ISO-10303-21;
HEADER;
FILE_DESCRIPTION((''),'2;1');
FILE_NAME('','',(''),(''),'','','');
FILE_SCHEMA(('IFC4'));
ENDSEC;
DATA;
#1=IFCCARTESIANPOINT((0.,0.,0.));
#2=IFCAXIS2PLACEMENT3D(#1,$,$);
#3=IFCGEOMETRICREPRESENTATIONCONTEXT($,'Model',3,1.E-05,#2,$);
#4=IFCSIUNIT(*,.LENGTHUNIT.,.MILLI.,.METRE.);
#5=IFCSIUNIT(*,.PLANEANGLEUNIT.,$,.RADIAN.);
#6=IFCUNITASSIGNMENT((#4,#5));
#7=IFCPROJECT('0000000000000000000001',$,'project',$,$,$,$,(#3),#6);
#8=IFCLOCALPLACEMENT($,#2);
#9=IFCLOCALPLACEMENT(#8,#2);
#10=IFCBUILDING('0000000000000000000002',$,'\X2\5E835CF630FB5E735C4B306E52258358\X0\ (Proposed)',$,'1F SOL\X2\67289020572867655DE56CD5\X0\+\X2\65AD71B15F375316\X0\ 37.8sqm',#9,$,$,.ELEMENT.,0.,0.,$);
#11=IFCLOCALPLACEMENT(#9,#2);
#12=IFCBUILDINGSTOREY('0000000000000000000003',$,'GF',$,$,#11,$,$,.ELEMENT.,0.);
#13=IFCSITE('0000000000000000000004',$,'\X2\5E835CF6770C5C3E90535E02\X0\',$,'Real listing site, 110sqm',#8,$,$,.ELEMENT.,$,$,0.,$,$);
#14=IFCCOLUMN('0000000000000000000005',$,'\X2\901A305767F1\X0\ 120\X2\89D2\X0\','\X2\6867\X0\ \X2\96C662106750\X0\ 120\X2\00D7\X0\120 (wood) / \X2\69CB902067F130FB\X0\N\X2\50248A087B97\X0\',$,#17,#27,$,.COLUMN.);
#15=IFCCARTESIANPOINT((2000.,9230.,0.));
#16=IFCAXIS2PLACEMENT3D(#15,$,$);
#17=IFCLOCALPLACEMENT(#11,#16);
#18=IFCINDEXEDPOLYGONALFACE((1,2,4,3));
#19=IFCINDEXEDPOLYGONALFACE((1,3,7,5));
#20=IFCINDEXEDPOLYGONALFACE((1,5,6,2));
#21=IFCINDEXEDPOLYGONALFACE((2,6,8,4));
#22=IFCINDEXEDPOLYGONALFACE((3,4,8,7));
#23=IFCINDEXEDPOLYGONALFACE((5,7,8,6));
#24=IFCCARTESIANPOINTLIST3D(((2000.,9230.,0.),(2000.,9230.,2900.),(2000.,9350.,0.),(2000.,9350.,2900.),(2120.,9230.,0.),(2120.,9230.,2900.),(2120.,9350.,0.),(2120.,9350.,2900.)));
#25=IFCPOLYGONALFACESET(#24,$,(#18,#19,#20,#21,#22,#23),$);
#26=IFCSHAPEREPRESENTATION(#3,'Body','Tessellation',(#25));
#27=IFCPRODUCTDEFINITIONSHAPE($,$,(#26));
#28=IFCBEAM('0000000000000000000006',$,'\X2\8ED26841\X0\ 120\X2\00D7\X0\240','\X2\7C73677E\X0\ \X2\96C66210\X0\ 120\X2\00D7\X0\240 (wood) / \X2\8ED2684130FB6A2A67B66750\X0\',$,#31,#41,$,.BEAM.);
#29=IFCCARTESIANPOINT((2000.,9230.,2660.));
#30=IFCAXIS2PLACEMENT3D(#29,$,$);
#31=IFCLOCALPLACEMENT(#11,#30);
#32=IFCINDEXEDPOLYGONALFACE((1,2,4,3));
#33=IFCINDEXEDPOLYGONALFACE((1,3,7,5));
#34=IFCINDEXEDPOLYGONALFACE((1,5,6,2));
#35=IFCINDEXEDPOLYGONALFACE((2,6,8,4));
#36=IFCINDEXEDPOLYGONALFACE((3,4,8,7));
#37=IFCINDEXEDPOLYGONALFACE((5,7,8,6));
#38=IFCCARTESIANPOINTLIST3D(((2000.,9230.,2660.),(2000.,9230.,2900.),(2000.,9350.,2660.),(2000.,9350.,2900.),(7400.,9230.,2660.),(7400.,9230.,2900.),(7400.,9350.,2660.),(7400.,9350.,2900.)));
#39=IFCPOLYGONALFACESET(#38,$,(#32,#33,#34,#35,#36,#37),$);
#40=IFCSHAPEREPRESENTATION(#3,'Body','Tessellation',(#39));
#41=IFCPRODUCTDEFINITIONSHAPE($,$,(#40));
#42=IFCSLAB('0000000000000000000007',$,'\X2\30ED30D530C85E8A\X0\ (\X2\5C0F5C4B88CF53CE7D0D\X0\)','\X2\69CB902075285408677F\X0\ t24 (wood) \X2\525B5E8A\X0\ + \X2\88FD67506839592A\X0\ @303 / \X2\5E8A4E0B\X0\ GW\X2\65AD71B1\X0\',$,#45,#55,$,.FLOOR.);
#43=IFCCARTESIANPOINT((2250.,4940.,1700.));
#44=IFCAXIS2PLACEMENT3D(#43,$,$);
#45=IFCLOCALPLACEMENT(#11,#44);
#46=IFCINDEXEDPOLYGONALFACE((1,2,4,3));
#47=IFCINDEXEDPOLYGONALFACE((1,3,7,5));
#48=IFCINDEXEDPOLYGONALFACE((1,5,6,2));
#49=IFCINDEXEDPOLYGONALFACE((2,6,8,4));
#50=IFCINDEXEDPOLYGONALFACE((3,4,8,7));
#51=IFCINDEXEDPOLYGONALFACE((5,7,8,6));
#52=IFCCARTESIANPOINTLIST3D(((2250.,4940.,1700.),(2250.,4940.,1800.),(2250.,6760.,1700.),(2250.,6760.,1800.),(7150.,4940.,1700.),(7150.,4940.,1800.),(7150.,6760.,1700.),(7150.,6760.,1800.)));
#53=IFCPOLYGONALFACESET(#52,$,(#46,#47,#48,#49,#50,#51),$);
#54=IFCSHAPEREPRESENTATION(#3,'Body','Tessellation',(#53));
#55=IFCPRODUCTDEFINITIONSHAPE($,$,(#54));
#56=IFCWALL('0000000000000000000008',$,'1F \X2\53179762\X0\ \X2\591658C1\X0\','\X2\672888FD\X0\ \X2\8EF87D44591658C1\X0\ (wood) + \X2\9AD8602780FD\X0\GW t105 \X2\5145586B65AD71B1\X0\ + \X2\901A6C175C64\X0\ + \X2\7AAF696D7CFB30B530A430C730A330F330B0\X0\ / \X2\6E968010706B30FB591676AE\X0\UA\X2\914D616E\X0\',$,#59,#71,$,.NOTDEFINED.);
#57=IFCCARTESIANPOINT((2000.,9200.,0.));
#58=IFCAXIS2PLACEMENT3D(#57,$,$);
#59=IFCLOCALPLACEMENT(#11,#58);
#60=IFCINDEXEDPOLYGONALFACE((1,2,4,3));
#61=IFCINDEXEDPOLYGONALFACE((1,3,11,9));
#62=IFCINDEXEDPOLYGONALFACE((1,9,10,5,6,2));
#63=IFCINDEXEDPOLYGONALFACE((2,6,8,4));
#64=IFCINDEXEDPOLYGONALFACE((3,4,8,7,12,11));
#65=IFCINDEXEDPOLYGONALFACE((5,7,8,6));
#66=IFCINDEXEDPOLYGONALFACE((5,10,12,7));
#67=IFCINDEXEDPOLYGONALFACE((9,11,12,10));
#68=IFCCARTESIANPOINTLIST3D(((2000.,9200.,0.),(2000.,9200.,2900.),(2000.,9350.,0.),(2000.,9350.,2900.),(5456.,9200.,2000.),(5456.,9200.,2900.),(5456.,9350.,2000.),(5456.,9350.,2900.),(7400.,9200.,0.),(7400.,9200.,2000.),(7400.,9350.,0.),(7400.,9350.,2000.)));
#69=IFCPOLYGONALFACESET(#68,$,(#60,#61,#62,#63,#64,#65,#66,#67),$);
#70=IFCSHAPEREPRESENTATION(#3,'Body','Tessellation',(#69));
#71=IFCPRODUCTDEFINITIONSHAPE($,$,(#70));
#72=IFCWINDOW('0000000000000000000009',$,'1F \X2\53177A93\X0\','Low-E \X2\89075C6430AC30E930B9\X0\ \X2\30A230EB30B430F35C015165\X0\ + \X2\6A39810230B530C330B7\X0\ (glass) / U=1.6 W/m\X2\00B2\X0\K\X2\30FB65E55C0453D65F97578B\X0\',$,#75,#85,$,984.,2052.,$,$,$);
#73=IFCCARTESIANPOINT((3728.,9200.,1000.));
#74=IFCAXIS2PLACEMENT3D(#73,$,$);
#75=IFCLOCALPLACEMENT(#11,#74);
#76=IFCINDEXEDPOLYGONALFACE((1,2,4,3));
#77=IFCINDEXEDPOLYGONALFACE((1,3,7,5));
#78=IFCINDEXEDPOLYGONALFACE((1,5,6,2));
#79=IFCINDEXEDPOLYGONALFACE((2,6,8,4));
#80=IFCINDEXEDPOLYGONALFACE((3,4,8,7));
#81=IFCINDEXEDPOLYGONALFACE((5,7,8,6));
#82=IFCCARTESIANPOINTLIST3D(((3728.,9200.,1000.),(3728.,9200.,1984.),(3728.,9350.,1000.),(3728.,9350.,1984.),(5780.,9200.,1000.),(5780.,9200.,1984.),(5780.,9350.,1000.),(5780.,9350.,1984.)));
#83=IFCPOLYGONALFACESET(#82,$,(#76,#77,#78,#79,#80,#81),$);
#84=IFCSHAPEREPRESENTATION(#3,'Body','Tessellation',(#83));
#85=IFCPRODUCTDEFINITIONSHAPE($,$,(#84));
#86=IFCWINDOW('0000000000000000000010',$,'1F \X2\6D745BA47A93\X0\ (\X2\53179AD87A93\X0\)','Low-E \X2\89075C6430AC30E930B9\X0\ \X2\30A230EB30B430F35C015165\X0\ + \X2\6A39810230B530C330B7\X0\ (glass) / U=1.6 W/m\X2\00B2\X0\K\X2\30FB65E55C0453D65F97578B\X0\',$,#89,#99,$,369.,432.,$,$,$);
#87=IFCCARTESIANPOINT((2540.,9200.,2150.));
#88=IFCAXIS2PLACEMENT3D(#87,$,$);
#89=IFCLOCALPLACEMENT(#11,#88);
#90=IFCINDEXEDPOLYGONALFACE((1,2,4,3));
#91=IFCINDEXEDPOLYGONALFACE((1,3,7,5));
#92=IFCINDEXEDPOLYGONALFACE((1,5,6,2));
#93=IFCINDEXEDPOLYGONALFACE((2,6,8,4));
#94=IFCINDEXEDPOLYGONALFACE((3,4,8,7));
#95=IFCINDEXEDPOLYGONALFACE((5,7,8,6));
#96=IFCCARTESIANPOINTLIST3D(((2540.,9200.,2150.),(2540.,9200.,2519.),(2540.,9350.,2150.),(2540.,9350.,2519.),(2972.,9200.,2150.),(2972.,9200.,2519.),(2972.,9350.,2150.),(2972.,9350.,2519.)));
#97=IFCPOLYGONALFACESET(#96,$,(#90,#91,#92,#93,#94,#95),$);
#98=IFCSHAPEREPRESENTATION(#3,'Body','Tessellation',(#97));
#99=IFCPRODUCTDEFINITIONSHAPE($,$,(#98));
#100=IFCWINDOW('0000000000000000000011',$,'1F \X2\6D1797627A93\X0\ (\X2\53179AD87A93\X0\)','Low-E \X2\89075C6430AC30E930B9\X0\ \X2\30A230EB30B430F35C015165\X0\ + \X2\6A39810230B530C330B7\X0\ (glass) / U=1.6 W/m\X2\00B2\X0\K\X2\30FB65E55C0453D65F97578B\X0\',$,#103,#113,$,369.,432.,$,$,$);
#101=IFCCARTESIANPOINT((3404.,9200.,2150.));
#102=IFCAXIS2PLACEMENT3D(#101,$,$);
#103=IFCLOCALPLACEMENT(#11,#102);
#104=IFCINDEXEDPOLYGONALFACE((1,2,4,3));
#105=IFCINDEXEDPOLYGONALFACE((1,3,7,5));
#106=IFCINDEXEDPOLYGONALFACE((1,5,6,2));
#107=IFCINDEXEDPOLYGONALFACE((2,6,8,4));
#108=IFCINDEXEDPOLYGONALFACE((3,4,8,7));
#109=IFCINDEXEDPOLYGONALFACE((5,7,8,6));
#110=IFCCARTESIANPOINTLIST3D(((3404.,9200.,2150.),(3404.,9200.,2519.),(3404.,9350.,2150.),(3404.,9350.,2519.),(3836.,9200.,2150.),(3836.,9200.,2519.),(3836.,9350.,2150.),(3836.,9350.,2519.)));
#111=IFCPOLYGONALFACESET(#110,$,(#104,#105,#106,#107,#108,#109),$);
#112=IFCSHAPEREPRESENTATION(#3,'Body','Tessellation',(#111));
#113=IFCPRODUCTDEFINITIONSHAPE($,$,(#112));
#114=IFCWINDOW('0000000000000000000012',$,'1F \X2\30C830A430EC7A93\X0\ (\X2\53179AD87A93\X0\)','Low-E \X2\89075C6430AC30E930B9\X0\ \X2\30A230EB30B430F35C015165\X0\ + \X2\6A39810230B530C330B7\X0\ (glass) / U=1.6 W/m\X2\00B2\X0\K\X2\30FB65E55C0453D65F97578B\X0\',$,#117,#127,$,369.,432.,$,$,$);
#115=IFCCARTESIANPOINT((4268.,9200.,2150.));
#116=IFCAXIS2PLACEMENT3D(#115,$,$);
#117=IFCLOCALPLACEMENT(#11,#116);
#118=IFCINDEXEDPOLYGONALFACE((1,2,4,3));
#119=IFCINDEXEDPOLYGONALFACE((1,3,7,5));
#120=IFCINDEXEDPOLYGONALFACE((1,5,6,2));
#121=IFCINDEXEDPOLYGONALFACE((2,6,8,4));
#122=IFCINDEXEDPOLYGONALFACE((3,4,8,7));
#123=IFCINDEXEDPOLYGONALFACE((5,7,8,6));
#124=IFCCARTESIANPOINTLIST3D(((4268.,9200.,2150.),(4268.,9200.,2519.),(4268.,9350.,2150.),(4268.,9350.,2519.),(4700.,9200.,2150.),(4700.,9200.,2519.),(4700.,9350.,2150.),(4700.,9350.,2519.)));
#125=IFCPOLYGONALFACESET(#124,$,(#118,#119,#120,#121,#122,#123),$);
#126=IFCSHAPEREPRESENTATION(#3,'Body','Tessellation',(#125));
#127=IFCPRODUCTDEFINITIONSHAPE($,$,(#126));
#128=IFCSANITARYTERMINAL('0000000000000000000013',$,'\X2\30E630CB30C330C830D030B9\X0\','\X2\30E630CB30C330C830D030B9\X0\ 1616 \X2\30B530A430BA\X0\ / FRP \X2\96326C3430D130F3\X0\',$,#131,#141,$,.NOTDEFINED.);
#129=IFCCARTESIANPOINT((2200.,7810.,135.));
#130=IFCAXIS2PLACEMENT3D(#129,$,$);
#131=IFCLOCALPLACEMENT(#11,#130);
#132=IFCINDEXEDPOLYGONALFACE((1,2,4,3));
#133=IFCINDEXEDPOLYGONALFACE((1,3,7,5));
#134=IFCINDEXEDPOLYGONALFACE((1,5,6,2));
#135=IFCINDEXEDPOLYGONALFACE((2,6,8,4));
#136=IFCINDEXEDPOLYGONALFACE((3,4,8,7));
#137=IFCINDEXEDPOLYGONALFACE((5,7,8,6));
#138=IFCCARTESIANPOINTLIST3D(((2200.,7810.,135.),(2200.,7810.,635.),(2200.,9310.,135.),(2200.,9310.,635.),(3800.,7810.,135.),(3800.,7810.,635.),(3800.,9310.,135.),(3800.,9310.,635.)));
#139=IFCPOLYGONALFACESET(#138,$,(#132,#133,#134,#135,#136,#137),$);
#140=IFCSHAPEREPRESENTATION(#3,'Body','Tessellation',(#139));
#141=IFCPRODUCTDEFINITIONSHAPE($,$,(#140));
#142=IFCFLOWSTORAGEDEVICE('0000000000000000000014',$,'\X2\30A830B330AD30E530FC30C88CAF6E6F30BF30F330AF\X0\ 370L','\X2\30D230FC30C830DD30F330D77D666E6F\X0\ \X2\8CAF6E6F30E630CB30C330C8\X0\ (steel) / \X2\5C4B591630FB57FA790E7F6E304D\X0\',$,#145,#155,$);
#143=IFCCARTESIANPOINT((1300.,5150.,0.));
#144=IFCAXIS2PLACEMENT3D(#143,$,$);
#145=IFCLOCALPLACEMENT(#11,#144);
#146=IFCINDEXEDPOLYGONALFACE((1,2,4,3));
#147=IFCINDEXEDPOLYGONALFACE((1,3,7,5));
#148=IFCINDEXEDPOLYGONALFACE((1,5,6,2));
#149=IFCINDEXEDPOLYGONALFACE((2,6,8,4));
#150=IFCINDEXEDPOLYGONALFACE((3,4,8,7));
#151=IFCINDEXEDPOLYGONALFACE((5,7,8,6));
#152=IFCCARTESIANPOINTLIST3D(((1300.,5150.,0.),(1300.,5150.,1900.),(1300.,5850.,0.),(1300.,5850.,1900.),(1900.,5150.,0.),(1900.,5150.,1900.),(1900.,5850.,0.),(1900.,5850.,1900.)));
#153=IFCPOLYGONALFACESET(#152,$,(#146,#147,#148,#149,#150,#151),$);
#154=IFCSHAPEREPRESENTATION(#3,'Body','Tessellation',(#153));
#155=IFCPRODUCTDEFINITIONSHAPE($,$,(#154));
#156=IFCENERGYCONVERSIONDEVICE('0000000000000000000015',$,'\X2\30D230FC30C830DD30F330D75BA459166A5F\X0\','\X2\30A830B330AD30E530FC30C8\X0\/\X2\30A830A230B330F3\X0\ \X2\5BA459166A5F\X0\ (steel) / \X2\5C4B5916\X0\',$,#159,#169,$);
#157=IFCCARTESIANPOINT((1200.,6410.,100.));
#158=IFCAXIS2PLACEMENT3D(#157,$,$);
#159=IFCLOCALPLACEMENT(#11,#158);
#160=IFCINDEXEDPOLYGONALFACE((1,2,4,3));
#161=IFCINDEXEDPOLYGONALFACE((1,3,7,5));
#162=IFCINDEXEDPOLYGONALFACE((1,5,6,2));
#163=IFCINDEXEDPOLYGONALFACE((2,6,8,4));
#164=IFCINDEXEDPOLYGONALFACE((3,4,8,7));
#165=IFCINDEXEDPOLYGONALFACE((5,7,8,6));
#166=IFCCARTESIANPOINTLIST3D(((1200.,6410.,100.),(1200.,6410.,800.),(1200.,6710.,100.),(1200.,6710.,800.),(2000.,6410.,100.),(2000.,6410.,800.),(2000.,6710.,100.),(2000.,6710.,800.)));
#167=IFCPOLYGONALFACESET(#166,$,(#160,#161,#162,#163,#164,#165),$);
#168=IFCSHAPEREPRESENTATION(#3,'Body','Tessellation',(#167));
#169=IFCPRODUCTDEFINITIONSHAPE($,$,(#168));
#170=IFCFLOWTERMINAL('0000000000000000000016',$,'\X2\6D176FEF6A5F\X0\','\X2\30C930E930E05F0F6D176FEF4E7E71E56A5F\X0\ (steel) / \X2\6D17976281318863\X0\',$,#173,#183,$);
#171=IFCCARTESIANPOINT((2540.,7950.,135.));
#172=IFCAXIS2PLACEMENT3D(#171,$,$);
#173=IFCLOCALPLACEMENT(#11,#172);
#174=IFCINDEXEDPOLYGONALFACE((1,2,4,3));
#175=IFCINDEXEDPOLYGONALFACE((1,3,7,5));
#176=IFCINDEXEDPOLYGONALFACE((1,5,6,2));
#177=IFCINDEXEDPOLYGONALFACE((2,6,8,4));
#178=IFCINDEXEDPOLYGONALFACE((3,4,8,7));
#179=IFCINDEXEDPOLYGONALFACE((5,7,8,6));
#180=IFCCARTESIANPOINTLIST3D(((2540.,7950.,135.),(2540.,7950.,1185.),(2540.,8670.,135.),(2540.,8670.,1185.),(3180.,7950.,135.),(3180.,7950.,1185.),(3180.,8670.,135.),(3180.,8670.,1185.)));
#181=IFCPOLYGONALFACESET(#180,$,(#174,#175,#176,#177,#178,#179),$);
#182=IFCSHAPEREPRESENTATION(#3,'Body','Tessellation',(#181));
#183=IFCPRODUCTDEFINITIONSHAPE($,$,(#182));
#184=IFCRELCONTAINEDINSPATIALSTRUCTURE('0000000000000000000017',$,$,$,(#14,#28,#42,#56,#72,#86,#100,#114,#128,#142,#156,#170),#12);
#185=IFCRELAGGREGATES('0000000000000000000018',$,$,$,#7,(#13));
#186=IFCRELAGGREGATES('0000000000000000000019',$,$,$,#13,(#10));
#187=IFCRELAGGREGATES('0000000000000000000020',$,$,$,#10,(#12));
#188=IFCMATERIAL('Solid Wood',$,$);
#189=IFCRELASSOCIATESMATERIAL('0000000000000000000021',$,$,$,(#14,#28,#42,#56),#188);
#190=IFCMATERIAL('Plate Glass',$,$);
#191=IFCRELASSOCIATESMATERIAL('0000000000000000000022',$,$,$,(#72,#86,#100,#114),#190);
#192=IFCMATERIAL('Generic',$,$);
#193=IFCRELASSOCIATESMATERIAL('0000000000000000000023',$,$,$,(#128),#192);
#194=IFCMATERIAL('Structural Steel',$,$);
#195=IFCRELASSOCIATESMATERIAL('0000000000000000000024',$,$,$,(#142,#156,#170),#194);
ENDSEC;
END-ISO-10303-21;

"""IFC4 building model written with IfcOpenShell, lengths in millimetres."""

from ifc_helpers import new_model, si_unit, frame, frame_2d, origin, place, context, project, spatial, rectangle, extrude, material, element, fill, save


model = new_model("IFC4")

# Units and contexts
model_context = context("Model", 3, precision=1e-05, world=origin())
ifc_project = project(units=[si_unit("LENGTHUNIT", "METRE", prefix="MILLI"), si_unit("PLANEANGLEUNIT", "RADIAN")], contexts=[model_context])

# Site, building, storey
site_placement = place(None, origin())
site = spatial("IfcSite", under=ifc_project, at=site_placement, Name="広島県尾道市", ObjectType="Real listing site, 110sqm", CompositionType="ELEMENT", RefElevation=0.0)
building_placement = place(site_placement, origin())
building = spatial("IfcBuilding", under=site, at=building_placement, Name="広島・平屋の別荘 (Proposed)", ObjectType="1F SOL木造在来工法+断熱強化 37.8sqm", CompositionType="ELEMENT", ElevationOfRefHeight=0.0, ElevationOfTerrain=0.0)
storey_placement = place(building_placement, origin())
storey = spatial("IfcBuildingStorey", under=building, at=storey_placement, Name="GF", CompositionType="ELEMENT", Elevation=0.0)

# Column
ifc_material_1 = material(Name="Solid Wood")
column_1_placement = place(storey_placement, frame((2000.0, 9230.0, 0.0)))
element("IfcColumn", 1, at=column_1_placement, inside=storey, material=ifc_material_1, Name="通し柱 120角", Description="桧 集成材 120×120 (wood) / 構造柱・N値計算", PredefinedType="COLUMN", context=model_context, shape_type="SweptSolid", body=[
    extrude(rectangle(XDim=120.0, YDim=120.0, at=frame_2d((60.0, 60.0))), frame((2000.0, 9230.0, 0.0)), (0.0, 0.0, 1.0), 2900.0),
])

# Beam
beam_1_placement = place(storey_placement, frame((2000.0, 9230.0, 2660.0)))
element("IfcBeam", 2, at=beam_1_placement, inside=storey, material=ifc_material_1, Name="軒桁 120×240", Description="米松 集成 120×240 (wood) / 軒桁・横架材", PredefinedType="BEAM", context=model_context, shape_type="SweptSolid", body=[
    extrude(rectangle(XDim=5400.0, YDim=120.0, at=frame_2d((2700.0, 60.0))), frame((2000.0, 9230.0, 2660.0)), (0.0, 0.0, 1.0), 240.0),
])

# Slab
slab_placement = place(storey_placement, frame((2250.0, 4940.0, 1700.0)))
element("IfcSlab", 3, at=slab_placement, inside=storey, material=ifc_material_1, Name="ロフト床 (小屋裏収納)", Description="構造用合板 t24 (wood) 剛床 + 製材根太 @303 / 床下 GW断熱", PredefinedType="FLOOR", context=model_context, shape_type="SweptSolid", body=[
    extrude(rectangle(XDim=4900.0, YDim=1820.0, at=frame_2d((2450.0, 910.0))), frame((2250.0, 4940.0, 1700.0)), (0.0, 0.0, 1.0), 100.0),
])

# Wall, openings, windows
wall_1_placement = place(storey_placement, frame((2000.0, 9200.0, 0.0)))
wall_1 = element("IfcWall", 4, at=wall_1_placement, inside=storey, material=ifc_material_1, Name="1F 北面 外壁", Description="木製 軸組外壁 (wood) + 高性能GW t105 充填断熱 + 通気層 + 窯業系サイディング / 準耐火・外皮UA配慮", PredefinedType="NOTDEFINED", context=model_context, shape_type="SweptSolid", body=[
    extrude(rectangle(XDim=5400.0, YDim=150.0, at=frame_2d((2700.0, 75.0))), frame((2000.0, 9200.0, 0.0)), (0.0, 0.0, 1.0), 2900.0),
])
opening_1_placement = place(storey_placement, frame((3728.0, 9200.0, 1000.0)))
opening_1 = element("IfcOpeningElement", 5, at=opening_1_placement, cuts=wall_1, PredefinedType="NOTDEFINED", context=model_context, shape_type="SweptSolid", body=[
    extrude(rectangle(XDim=2052.0, YDim=150.0, at=frame_2d((1026.0, 75.0))), frame((3728.0, 9200.0, 1000.0)), (0.0, 0.0, 1.0), 984.0),
])
opening_2_placement = place(storey_placement, frame((2540.0, 9200.0, 2150.0)))
opening_2 = element("IfcOpeningElement", 6, at=opening_2_placement, cuts=wall_1, PredefinedType="NOTDEFINED", context=model_context, shape_type="SweptSolid", body=[
    extrude(rectangle(XDim=432.0, YDim=150.0, at=frame_2d((216.0, 75.0))), frame((2540.0, 9200.0, 2150.0)), (0.0, 0.0, 1.0), 369.0),
])
opening_3_placement = place(storey_placement, frame((3404.0, 9200.0, 2150.0)))
opening_3 = element("IfcOpeningElement", 7, at=opening_3_placement, cuts=wall_1, PredefinedType="NOTDEFINED", context=model_context, shape_type="SweptSolid", body=[
    extrude(rectangle(XDim=432.0, YDim=150.0, at=frame_2d((216.0, 75.0))), frame((3404.0, 9200.0, 2150.0)), (0.0, 0.0, 1.0), 369.0),
])
opening_4_placement = place(storey_placement, frame((4268.0, 9200.0, 2150.0)))
opening_4 = element("IfcOpeningElement", 8, at=opening_4_placement, cuts=wall_1, PredefinedType="NOTDEFINED", context=model_context, shape_type="SweptSolid", body=[
    extrude(rectangle(XDim=432.0, YDim=150.0, at=frame_2d((216.0, 75.0))), frame((4268.0, 9200.0, 2150.0)), (0.0, 0.0, 1.0), 369.0),
])
ifc_material_2 = material(Name="Plate Glass")
window_1_placement = place(storey_placement, frame((3728.0, 9200.0, 1000.0)))
window_1 = element("IfcWindow", 9, at=window_1_placement, inside=storey, material=ifc_material_2, Name="1F 北窓", Description="Low-E 複層ガラス アルゴン封入 + 樹脂サッシ (glass) / U=1.6 W/m²K・日射取得型", OverallHeight=984.0, OverallWidth=2052.0, context=model_context, shape_type="SweptSolid", body=[
    extrude(rectangle(XDim=2052.0, YDim=150.0, at=frame_2d((1026.0, 75.0))), frame((3728.0, 9200.0, 1000.0)), (0.0, 0.0, 1.0), 984.0),
])
fill(opening_1, window_1)
window_2_placement = place(storey_placement, frame((2540.0, 9200.0, 2150.0)))
window_2 = element("IfcWindow", 10, at=window_2_placement, inside=storey, material=ifc_material_2, Name="1F 浴室窓 (北高窓)", Description="Low-E 複層ガラス アルゴン封入 + 樹脂サッシ (glass) / U=1.6 W/m²K・日射取得型", OverallHeight=369.0, OverallWidth=432.0, context=model_context, shape_type="SweptSolid", body=[
    extrude(rectangle(XDim=432.0, YDim=150.0, at=frame_2d((216.0, 75.0))), frame((2540.0, 9200.0, 2150.0)), (0.0, 0.0, 1.0), 369.0),
])
fill(opening_2, window_2)
window_3_placement = place(storey_placement, frame((3404.0, 9200.0, 2150.0)))
window_3 = element("IfcWindow", 11, at=window_3_placement, inside=storey, material=ifc_material_2, Name="1F 洗面窓 (北高窓)", Description="Low-E 複層ガラス アルゴン封入 + 樹脂サッシ (glass) / U=1.6 W/m²K・日射取得型", OverallHeight=369.0, OverallWidth=432.0, context=model_context, shape_type="SweptSolid", body=[
    extrude(rectangle(XDim=432.0, YDim=150.0, at=frame_2d((216.0, 75.0))), frame((3404.0, 9200.0, 2150.0)), (0.0, 0.0, 1.0), 369.0),
])
fill(opening_3, window_3)
window_4_placement = place(storey_placement, frame((4268.0, 9200.0, 2150.0)))
window_4 = element("IfcWindow", 12, at=window_4_placement, inside=storey, material=ifc_material_2, Name="1F トイレ窓 (北高窓)", Description="Low-E 複層ガラス アルゴン封入 + 樹脂サッシ (glass) / U=1.6 W/m²K・日射取得型", OverallHeight=369.0, OverallWidth=432.0, context=model_context, shape_type="SweptSolid", body=[
    extrude(rectangle(XDim=432.0, YDim=150.0, at=frame_2d((216.0, 75.0))), frame((4268.0, 9200.0, 2150.0)), (0.0, 0.0, 1.0), 369.0),
])
fill(opening_4, window_4)

# Sanitary terminal
ifc_material_3 = material(Name="Generic")
sanitary_terminal_placement = place(storey_placement, frame((2200.0, 7810.0, 135.0)))
element("IfcSanitaryTerminal", 13, at=sanitary_terminal_placement, inside=storey, material=ifc_material_3, Name="ユニットバス", Description="ユニットバス 1616 サイズ / FRP 防水パン", PredefinedType="NOTDEFINED", context=model_context, shape_type="SweptSolid", body=[
    extrude(rectangle(XDim=1600.0, YDim=1500.0, at=frame_2d((800.0, 750.0))), frame((2200.0, 7810.0, 135.0)), (0.0, 0.0, 1.0), 500.0),
])

# Flow storage device
ifc_material_4 = material(Name="Structural Steel")
flow_storage_device_placement = place(storey_placement, frame((1300.0, 5150.0, 0.0)))
element("IfcFlowStorageDevice", 14, at=flow_storage_device_placement, inside=storey, material=ifc_material_4, Name="エコキュート貯湯タンク 370L", Description="ヒートポンプ給湯 貯湯ユニット (steel) / 屋外・基礎置き", context=model_context, shape_type="SweptSolid", body=[
    extrude(rectangle(XDim=600.0, YDim=700.0, at=frame_2d((300.0, 350.0))), frame((1300.0, 5150.0, 0.0)), (0.0, 0.0, 1.0), 1900.0),
])

# Energy conversion device
energy_conversion_device_placement = place(storey_placement, frame((1200.0, 6410.0, 100.0)))
element("IfcEnergyConversionDevice", 15, at=energy_conversion_device_placement, inside=storey, material=ifc_material_4, Name="ヒートポンプ室外機", Description="エコキュート/エアコン 室外機 (steel) / 屋外", context=model_context, shape_type="SweptSolid", body=[
    extrude(rectangle(XDim=800.0, YDim=300.0, at=frame_2d((400.0, 150.0))), frame((1200.0, 6410.0, 100.0)), (0.0, 0.0, 1.0), 700.0),
])

# Flow terminal
flow_terminal_placement = place(storey_placement, frame((2540.0, 7950.0, 135.0)))
element("IfcFlowTerminal", 16, at=flow_terminal_placement, inside=storey, material=ifc_material_4, Name="洗濯機", Description="ドラム式洗濯乾燥機 (steel) / 洗面脱衣", context=model_context, shape_type="SweptSolid", body=[
    extrude(rectangle(XDim=640.0, YDim=720.0, at=frame_2d((320.0, 360.0))), frame((2540.0, 7950.0, 135.0)), (0.0, 0.0, 1.0), 1050.0),
])

save(model, "model.ifc")
